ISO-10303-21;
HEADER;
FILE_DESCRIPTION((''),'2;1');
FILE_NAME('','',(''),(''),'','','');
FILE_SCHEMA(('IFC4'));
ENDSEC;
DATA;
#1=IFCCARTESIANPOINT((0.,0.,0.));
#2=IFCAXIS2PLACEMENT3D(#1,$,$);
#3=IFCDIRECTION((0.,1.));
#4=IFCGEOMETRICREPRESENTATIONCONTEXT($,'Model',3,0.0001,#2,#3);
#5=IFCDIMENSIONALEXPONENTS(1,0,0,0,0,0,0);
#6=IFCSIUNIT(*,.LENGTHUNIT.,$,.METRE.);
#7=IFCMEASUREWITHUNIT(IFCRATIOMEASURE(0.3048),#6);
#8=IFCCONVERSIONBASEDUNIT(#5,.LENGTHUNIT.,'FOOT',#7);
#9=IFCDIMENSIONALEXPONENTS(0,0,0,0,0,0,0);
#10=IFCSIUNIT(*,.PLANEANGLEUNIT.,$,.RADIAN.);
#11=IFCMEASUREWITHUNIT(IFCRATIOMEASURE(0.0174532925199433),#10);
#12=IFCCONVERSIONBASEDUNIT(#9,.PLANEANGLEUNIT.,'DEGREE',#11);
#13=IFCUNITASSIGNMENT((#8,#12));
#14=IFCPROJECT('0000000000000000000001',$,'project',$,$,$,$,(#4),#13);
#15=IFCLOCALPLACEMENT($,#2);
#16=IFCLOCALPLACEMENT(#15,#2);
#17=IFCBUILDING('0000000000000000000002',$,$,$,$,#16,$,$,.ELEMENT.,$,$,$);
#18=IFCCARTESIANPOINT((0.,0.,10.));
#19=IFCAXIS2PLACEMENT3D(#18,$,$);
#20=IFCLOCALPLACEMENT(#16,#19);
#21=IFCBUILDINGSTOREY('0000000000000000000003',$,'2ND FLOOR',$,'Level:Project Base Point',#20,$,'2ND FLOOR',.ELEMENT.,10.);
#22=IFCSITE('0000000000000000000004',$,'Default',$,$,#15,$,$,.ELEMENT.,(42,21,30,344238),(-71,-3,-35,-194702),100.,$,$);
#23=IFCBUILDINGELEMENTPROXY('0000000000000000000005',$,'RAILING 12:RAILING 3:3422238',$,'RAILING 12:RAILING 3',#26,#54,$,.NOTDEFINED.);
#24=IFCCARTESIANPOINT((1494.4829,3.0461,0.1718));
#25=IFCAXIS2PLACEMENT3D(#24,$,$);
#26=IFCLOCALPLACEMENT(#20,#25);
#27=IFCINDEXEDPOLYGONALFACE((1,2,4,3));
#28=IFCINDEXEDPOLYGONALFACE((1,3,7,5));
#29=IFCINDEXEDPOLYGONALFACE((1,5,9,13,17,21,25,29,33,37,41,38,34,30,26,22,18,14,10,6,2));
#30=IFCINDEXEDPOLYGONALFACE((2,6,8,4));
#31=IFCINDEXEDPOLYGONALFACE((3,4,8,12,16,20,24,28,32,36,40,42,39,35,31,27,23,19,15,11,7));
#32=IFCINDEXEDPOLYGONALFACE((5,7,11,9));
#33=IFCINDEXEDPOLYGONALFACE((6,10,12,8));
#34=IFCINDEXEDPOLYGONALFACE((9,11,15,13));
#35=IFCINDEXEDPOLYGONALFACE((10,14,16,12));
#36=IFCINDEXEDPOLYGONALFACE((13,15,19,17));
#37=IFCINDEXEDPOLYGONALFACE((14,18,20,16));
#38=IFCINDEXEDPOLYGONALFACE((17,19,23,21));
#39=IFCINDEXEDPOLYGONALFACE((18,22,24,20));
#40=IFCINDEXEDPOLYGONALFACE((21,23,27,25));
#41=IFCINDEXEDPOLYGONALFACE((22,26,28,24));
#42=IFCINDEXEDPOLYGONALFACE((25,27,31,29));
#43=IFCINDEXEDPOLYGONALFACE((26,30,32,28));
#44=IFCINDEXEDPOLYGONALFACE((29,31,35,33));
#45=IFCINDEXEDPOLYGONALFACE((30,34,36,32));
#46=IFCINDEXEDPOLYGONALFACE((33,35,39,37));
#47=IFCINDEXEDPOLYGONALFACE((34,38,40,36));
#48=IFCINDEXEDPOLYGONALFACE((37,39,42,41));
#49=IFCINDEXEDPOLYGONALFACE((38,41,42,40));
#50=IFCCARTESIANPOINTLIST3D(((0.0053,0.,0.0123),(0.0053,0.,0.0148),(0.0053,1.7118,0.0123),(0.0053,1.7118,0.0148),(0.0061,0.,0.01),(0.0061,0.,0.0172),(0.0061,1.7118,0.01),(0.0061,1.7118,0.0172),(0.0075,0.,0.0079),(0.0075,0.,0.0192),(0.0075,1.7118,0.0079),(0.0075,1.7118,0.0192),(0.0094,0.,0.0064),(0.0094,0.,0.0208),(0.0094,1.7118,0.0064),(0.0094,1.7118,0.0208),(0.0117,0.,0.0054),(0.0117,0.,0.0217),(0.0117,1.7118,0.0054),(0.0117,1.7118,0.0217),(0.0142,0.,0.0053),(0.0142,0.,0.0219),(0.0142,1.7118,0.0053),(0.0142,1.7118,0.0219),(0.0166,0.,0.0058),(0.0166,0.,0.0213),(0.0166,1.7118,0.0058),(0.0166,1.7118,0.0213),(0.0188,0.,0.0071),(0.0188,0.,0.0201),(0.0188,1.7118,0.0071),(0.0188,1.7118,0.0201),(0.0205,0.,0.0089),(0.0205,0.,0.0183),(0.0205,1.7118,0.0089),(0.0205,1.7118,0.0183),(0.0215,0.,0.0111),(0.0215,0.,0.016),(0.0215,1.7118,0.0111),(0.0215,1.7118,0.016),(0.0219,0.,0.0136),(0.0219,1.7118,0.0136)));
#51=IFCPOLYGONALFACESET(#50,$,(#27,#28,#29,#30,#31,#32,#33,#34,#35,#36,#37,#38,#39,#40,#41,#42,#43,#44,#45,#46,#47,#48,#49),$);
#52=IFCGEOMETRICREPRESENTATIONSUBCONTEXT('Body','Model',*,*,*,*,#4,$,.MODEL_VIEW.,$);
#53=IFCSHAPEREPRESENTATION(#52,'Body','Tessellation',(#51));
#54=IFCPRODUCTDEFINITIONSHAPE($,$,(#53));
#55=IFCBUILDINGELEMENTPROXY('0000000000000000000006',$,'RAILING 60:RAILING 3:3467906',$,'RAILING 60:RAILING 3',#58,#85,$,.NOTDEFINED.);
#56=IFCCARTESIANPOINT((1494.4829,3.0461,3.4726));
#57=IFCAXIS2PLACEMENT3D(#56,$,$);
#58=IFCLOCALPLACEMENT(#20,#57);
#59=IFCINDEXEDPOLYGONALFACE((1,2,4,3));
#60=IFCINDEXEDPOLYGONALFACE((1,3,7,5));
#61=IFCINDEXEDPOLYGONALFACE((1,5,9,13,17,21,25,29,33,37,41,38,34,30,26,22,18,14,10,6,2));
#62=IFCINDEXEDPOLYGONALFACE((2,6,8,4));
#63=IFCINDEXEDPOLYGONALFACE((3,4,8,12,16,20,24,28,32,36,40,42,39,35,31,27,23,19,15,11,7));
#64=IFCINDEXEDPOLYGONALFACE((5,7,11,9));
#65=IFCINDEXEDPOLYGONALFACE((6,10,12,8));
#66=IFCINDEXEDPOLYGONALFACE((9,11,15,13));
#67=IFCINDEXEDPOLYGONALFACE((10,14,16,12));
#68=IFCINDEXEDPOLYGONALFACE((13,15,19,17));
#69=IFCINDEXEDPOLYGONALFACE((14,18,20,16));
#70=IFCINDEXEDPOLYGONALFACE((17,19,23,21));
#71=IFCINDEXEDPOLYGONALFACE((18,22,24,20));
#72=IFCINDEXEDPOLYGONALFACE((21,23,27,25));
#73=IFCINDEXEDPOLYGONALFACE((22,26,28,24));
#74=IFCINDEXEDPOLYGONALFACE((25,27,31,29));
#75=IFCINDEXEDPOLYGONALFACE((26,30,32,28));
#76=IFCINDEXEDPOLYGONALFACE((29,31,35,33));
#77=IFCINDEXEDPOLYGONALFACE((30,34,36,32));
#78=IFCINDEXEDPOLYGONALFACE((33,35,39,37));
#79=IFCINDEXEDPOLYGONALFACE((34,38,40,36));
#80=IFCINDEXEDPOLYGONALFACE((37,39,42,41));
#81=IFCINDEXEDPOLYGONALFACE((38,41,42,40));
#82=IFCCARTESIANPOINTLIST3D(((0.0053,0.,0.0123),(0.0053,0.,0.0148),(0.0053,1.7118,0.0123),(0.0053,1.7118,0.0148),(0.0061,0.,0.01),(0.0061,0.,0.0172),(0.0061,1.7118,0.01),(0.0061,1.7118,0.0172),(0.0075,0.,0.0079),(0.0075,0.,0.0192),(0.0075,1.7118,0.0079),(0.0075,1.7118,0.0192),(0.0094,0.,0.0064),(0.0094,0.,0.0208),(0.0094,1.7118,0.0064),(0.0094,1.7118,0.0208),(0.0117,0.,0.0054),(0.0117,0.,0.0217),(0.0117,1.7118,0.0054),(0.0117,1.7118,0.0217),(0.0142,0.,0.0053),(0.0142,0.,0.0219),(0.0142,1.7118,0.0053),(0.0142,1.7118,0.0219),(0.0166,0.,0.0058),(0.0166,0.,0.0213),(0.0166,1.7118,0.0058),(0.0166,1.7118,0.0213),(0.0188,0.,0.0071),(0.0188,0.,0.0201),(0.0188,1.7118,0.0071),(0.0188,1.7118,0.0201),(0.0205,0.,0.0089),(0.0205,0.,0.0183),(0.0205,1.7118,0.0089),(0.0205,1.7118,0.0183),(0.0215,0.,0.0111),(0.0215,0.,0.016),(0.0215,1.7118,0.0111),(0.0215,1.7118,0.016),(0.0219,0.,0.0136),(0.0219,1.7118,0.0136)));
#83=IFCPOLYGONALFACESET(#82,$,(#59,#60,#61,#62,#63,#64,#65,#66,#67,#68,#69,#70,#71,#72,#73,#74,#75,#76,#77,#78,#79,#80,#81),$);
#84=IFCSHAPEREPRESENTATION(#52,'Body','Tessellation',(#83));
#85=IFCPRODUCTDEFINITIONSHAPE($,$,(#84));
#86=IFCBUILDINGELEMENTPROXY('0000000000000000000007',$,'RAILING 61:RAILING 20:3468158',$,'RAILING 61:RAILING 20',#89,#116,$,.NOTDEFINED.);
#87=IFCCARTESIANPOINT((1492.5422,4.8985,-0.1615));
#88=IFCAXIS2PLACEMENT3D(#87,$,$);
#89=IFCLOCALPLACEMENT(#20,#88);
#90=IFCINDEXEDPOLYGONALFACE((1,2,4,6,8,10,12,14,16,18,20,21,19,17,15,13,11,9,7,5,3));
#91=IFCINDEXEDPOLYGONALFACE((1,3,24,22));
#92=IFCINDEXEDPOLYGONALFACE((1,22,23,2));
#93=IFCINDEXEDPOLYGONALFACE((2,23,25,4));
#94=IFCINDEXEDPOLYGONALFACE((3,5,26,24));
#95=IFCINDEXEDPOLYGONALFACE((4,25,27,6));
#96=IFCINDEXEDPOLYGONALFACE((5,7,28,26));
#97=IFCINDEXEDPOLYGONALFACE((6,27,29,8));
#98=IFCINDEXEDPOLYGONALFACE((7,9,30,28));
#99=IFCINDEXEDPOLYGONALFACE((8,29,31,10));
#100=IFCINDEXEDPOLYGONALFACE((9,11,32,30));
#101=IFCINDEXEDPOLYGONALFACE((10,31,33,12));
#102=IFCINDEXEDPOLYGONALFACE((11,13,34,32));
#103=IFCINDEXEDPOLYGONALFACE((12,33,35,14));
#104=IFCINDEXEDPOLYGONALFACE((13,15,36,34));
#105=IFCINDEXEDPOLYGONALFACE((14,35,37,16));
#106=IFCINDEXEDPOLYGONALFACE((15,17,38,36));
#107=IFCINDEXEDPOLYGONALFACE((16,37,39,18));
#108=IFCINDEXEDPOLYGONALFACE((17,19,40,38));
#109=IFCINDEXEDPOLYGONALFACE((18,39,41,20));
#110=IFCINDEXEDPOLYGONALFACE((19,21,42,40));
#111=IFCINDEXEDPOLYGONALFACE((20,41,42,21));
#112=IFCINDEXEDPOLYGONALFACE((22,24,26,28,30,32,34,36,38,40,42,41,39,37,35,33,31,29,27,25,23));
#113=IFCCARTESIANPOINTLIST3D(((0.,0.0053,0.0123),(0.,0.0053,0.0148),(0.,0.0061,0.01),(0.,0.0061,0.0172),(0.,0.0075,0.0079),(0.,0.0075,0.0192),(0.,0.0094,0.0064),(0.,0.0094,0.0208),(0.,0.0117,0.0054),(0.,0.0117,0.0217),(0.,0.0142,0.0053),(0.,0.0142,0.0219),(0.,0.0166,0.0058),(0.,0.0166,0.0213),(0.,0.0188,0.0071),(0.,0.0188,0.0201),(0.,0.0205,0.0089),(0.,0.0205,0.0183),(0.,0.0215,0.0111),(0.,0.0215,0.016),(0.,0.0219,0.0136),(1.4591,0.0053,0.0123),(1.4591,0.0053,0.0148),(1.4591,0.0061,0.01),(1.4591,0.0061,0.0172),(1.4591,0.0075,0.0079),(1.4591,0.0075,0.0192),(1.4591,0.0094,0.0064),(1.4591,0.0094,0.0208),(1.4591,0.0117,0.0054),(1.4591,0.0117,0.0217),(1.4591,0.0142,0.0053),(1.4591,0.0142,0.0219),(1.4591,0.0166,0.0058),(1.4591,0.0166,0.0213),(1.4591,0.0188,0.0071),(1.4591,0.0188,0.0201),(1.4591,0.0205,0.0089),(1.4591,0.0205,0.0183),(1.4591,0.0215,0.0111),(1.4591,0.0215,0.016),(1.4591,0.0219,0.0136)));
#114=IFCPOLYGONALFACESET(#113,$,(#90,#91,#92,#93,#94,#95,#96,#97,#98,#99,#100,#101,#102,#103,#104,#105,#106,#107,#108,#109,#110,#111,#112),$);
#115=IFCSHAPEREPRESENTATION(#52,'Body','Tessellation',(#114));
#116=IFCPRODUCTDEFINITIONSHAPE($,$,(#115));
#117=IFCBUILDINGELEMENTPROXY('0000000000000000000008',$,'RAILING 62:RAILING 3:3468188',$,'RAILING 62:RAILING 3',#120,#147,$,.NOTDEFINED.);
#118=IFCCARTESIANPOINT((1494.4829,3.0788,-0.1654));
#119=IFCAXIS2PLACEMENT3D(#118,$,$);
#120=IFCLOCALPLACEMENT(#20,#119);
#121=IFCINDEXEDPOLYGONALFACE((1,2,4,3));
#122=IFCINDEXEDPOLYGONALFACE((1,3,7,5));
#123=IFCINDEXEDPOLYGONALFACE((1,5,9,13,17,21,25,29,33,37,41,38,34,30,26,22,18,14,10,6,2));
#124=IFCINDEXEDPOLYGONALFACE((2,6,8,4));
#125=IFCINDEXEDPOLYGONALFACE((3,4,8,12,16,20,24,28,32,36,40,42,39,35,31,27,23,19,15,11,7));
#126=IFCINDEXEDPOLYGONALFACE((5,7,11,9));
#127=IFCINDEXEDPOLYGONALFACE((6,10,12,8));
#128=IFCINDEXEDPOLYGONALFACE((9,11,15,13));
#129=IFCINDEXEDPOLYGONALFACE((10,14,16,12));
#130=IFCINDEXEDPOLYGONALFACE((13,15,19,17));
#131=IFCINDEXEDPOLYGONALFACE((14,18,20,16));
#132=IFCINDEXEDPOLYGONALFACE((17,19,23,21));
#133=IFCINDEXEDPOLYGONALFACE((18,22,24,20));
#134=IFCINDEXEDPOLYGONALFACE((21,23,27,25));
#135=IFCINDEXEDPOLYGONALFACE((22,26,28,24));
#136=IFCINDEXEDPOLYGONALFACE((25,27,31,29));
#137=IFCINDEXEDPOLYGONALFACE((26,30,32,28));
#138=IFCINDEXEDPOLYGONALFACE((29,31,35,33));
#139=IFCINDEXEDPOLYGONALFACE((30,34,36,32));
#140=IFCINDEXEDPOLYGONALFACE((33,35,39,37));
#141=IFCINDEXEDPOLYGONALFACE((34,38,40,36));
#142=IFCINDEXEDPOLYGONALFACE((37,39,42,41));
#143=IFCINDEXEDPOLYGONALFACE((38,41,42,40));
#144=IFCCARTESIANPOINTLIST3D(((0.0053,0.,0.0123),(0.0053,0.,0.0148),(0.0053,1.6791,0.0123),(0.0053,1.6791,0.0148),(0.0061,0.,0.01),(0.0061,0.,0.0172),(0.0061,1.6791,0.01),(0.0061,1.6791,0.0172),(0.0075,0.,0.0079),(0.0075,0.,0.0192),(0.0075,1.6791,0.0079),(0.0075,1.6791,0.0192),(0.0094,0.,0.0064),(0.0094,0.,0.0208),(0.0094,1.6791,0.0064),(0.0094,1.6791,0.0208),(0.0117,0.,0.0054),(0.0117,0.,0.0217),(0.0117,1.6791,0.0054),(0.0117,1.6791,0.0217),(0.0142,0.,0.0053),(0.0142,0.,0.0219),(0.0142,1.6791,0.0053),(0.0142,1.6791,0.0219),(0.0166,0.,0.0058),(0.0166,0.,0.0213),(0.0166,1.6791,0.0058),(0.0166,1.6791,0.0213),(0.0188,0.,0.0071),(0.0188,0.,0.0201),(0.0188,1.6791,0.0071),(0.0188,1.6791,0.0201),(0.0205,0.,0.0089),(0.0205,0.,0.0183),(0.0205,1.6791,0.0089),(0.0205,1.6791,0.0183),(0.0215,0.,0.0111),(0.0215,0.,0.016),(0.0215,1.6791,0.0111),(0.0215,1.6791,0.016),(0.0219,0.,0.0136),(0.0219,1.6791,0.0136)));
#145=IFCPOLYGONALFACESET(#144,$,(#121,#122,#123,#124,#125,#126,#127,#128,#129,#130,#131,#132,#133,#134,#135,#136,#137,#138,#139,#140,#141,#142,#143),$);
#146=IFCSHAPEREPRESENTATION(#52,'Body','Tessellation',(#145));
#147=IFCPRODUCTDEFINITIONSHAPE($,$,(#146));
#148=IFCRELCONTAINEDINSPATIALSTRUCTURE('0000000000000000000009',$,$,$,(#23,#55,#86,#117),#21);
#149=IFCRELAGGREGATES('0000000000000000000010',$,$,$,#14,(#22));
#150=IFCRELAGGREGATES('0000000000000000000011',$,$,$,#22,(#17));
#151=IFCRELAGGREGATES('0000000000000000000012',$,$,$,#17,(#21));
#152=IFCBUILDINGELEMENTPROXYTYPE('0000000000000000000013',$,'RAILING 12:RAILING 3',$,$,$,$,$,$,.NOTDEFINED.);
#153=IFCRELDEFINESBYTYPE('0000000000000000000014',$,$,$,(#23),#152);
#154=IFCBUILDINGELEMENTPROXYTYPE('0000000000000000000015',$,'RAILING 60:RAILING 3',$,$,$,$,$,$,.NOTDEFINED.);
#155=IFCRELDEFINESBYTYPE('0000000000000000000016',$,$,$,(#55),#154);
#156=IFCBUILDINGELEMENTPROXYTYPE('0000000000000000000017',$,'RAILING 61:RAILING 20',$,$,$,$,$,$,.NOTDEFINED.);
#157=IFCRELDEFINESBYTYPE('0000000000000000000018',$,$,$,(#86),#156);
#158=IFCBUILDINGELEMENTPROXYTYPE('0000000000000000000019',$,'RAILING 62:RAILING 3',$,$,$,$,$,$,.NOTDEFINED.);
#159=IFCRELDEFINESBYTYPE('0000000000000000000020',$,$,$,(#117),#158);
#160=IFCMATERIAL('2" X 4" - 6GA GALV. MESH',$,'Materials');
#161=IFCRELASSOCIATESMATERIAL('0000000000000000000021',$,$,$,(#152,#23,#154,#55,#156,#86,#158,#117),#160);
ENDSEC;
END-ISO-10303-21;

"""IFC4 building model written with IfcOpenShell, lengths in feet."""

from ifc_helpers import new_model, entity, si_unit, converted_unit, direction, frame, origin, origin_2d_with_axis, place, context, subcontext, project, spatial, circle, extrude, source, transform, mapped, material, type_object, type_shapes, element, save


model = new_model("IFC4")

# Units and contexts
model_context = context("Model", 3, precision=0.0001, world=origin(), true_north=direction((0.0, 1.0)))
body_context = subcontext(model_context, "Body", "Model", "MODEL_VIEW")
ifc_project = project(units=[converted_unit("LENGTHUNIT", "FOOT", entity("IfcRatioMeasure", 0.3048), si_unit("LENGTHUNIT", "METRE"), dimensions=[1, 0, 0, 0, 0, 0, 0]), converted_unit("PLANEANGLEUNIT", "DEGREE", entity("IfcRatioMeasure", 0.0174532925199433), si_unit("PLANEANGLEUNIT", "RADIAN"), dimensions=[0, 0, 0, 0, 0, 0, 0])], contexts=[model_context])

# Site, building, storey
site_placement = place(None, origin())
site = spatial("IfcSite", under=ifc_project, at=site_placement, Name="Default", CompositionType="ELEMENT", RefLatitude=(42, 21, 30, 344238), RefLongitude=(-71, -3, -35, -194702), RefElevation=100.0)
building_placement = place(site_placement, origin())
building = spatial("IfcBuilding", under=site, at=building_placement, CompositionType="ELEMENT")
storey_placement = place(building_placement, frame((0.0, 0.0, 10.0)))
storey = spatial("IfcBuildingStorey", under=building, at=storey_placement, Name="2ND FLOOR", ObjectType="Level:Project Base Point", LongName="2ND FLOOR", CompositionType="ELEMENT", Elevation=10.0)

# Building element proxies
ifc_material_1 = material(Name="2\" X 4\" - 6GA GALV. MESH", Category="Materials")
building_element_proxy_type_1 = type_object("IfcBuildingElementProxyType", Name="RAILING 12:RAILING 3", PredefinedType="NOTDEFINED", material=ifc_material_1)
shared_shape_1 = source(origin(), body_context, "Body", "SweptSolid", [
    extrude(circle(Radius=0.0083, at=origin_2d_with_axis()), frame((0.0136, 0.0, 0.0136), z_axis=(0.0, 1.0, 0.0), x_axis=(1.0, 0.0, 0.0)), (0.0, 0.0, 1.0), 1.7118),
])
type_shapes(building_element_proxy_type_1, [shared_shape_1])
proxy_1_placement = place(storey_placement, frame((1494.4829, 3.0461, 0.1718)))
element("IfcBuildingElementProxy", 1, at=proxy_1_placement, inside=storey, type_object=building_element_proxy_type_1, material=ifc_material_1, Name="RAILING 12:RAILING 3:3422238", ObjectType="RAILING 12:RAILING 3", PredefinedType="NOTDEFINED", context=body_context, shape_type="MappedRepresentation", body=[
    mapped(shared_shape_1, transform((0.0, 0.0, 0.0), scale=1.0)),
])
building_element_proxy_type_2 = type_object("IfcBuildingElementProxyType", Name="RAILING 60:RAILING 3", PredefinedType="NOTDEFINED", material=ifc_material_1)
shared_shape_2 = source(origin(), body_context, "Body", "SweptSolid", [
    extrude(circle(Radius=0.0083, at=origin_2d_with_axis()), frame((0.0136, 0.0, 0.0136), z_axis=(0.0, 1.0, 0.0), x_axis=(1.0, 0.0, 0.0)), (0.0, 0.0, 1.0), 1.7118),
])
type_shapes(building_element_proxy_type_2, [shared_shape_2])
proxy_2_placement = place(storey_placement, frame((1494.4829, 3.0461, 3.4726)))
element("IfcBuildingElementProxy", 2, at=proxy_2_placement, inside=storey, type_object=building_element_proxy_type_2, material=ifc_material_1, Name="RAILING 60:RAILING 3:3467906", ObjectType="RAILING 60:RAILING 3", PredefinedType="NOTDEFINED", context=body_context, shape_type="MappedRepresentation", body=[
    mapped(shared_shape_2, transform((0.0, 0.0, 0.0), scale=1.0)),
])
building_element_proxy_type_3 = type_object("IfcBuildingElementProxyType", Name="RAILING 61:RAILING 20", PredefinedType="NOTDEFINED", material=ifc_material_1)
shared_shape_3 = source(origin(), body_context, "Body", "SweptSolid", [
    extrude(circle(Radius=0.0083, at=origin_2d_with_axis()), frame((0.0, 0.0136, 0.0136), z_axis=(1.0, 0.0, 0.0), x_axis=(0.0, 1.0, 0.0)), (0.0, 0.0, 1.0), 1.4591),
])
type_shapes(building_element_proxy_type_3, [shared_shape_3])
proxy_3_placement = place(storey_placement, frame((1492.5422, 4.8985, -0.1615)))
element("IfcBuildingElementProxy", 3, at=proxy_3_placement, inside=storey, type_object=building_element_proxy_type_3, material=ifc_material_1, Name="RAILING 61:RAILING 20:3468158", ObjectType="RAILING 61:RAILING 20", PredefinedType="NOTDEFINED", context=body_context, shape_type="MappedRepresentation", body=[
    mapped(shared_shape_3, transform((0.0, 0.0, 0.0), scale=1.0)),
])
building_element_proxy_type_4 = type_object("IfcBuildingElementProxyType", Name="RAILING 62:RAILING 3", PredefinedType="NOTDEFINED", material=ifc_material_1)
shared_shape_4 = source(origin(), body_context, "Body", "SweptSolid", [
    extrude(circle(Radius=0.0083, at=origin_2d_with_axis()), frame((0.0136, 0.0, 0.0136), z_axis=(0.0, 1.0, 0.0), x_axis=(1.0, 0.0, 0.0)), (0.0, 0.0, 1.0), 1.6791),
])
type_shapes(building_element_proxy_type_4, [shared_shape_4])
proxy_4_placement = place(storey_placement, frame((1494.4829, 3.0788, -0.1654)))
element("IfcBuildingElementProxy", 4, at=proxy_4_placement, inside=storey, type_object=building_element_proxy_type_4, material=ifc_material_1, Name="RAILING 62:RAILING 3:3468188", ObjectType="RAILING 62:RAILING 3", PredefinedType="NOTDEFINED", context=body_context, shape_type="MappedRepresentation", body=[
    mapped(shared_shape_4, transform((0.0, 0.0, 0.0), scale=1.0)),
])

save(model, "model.ifc")
